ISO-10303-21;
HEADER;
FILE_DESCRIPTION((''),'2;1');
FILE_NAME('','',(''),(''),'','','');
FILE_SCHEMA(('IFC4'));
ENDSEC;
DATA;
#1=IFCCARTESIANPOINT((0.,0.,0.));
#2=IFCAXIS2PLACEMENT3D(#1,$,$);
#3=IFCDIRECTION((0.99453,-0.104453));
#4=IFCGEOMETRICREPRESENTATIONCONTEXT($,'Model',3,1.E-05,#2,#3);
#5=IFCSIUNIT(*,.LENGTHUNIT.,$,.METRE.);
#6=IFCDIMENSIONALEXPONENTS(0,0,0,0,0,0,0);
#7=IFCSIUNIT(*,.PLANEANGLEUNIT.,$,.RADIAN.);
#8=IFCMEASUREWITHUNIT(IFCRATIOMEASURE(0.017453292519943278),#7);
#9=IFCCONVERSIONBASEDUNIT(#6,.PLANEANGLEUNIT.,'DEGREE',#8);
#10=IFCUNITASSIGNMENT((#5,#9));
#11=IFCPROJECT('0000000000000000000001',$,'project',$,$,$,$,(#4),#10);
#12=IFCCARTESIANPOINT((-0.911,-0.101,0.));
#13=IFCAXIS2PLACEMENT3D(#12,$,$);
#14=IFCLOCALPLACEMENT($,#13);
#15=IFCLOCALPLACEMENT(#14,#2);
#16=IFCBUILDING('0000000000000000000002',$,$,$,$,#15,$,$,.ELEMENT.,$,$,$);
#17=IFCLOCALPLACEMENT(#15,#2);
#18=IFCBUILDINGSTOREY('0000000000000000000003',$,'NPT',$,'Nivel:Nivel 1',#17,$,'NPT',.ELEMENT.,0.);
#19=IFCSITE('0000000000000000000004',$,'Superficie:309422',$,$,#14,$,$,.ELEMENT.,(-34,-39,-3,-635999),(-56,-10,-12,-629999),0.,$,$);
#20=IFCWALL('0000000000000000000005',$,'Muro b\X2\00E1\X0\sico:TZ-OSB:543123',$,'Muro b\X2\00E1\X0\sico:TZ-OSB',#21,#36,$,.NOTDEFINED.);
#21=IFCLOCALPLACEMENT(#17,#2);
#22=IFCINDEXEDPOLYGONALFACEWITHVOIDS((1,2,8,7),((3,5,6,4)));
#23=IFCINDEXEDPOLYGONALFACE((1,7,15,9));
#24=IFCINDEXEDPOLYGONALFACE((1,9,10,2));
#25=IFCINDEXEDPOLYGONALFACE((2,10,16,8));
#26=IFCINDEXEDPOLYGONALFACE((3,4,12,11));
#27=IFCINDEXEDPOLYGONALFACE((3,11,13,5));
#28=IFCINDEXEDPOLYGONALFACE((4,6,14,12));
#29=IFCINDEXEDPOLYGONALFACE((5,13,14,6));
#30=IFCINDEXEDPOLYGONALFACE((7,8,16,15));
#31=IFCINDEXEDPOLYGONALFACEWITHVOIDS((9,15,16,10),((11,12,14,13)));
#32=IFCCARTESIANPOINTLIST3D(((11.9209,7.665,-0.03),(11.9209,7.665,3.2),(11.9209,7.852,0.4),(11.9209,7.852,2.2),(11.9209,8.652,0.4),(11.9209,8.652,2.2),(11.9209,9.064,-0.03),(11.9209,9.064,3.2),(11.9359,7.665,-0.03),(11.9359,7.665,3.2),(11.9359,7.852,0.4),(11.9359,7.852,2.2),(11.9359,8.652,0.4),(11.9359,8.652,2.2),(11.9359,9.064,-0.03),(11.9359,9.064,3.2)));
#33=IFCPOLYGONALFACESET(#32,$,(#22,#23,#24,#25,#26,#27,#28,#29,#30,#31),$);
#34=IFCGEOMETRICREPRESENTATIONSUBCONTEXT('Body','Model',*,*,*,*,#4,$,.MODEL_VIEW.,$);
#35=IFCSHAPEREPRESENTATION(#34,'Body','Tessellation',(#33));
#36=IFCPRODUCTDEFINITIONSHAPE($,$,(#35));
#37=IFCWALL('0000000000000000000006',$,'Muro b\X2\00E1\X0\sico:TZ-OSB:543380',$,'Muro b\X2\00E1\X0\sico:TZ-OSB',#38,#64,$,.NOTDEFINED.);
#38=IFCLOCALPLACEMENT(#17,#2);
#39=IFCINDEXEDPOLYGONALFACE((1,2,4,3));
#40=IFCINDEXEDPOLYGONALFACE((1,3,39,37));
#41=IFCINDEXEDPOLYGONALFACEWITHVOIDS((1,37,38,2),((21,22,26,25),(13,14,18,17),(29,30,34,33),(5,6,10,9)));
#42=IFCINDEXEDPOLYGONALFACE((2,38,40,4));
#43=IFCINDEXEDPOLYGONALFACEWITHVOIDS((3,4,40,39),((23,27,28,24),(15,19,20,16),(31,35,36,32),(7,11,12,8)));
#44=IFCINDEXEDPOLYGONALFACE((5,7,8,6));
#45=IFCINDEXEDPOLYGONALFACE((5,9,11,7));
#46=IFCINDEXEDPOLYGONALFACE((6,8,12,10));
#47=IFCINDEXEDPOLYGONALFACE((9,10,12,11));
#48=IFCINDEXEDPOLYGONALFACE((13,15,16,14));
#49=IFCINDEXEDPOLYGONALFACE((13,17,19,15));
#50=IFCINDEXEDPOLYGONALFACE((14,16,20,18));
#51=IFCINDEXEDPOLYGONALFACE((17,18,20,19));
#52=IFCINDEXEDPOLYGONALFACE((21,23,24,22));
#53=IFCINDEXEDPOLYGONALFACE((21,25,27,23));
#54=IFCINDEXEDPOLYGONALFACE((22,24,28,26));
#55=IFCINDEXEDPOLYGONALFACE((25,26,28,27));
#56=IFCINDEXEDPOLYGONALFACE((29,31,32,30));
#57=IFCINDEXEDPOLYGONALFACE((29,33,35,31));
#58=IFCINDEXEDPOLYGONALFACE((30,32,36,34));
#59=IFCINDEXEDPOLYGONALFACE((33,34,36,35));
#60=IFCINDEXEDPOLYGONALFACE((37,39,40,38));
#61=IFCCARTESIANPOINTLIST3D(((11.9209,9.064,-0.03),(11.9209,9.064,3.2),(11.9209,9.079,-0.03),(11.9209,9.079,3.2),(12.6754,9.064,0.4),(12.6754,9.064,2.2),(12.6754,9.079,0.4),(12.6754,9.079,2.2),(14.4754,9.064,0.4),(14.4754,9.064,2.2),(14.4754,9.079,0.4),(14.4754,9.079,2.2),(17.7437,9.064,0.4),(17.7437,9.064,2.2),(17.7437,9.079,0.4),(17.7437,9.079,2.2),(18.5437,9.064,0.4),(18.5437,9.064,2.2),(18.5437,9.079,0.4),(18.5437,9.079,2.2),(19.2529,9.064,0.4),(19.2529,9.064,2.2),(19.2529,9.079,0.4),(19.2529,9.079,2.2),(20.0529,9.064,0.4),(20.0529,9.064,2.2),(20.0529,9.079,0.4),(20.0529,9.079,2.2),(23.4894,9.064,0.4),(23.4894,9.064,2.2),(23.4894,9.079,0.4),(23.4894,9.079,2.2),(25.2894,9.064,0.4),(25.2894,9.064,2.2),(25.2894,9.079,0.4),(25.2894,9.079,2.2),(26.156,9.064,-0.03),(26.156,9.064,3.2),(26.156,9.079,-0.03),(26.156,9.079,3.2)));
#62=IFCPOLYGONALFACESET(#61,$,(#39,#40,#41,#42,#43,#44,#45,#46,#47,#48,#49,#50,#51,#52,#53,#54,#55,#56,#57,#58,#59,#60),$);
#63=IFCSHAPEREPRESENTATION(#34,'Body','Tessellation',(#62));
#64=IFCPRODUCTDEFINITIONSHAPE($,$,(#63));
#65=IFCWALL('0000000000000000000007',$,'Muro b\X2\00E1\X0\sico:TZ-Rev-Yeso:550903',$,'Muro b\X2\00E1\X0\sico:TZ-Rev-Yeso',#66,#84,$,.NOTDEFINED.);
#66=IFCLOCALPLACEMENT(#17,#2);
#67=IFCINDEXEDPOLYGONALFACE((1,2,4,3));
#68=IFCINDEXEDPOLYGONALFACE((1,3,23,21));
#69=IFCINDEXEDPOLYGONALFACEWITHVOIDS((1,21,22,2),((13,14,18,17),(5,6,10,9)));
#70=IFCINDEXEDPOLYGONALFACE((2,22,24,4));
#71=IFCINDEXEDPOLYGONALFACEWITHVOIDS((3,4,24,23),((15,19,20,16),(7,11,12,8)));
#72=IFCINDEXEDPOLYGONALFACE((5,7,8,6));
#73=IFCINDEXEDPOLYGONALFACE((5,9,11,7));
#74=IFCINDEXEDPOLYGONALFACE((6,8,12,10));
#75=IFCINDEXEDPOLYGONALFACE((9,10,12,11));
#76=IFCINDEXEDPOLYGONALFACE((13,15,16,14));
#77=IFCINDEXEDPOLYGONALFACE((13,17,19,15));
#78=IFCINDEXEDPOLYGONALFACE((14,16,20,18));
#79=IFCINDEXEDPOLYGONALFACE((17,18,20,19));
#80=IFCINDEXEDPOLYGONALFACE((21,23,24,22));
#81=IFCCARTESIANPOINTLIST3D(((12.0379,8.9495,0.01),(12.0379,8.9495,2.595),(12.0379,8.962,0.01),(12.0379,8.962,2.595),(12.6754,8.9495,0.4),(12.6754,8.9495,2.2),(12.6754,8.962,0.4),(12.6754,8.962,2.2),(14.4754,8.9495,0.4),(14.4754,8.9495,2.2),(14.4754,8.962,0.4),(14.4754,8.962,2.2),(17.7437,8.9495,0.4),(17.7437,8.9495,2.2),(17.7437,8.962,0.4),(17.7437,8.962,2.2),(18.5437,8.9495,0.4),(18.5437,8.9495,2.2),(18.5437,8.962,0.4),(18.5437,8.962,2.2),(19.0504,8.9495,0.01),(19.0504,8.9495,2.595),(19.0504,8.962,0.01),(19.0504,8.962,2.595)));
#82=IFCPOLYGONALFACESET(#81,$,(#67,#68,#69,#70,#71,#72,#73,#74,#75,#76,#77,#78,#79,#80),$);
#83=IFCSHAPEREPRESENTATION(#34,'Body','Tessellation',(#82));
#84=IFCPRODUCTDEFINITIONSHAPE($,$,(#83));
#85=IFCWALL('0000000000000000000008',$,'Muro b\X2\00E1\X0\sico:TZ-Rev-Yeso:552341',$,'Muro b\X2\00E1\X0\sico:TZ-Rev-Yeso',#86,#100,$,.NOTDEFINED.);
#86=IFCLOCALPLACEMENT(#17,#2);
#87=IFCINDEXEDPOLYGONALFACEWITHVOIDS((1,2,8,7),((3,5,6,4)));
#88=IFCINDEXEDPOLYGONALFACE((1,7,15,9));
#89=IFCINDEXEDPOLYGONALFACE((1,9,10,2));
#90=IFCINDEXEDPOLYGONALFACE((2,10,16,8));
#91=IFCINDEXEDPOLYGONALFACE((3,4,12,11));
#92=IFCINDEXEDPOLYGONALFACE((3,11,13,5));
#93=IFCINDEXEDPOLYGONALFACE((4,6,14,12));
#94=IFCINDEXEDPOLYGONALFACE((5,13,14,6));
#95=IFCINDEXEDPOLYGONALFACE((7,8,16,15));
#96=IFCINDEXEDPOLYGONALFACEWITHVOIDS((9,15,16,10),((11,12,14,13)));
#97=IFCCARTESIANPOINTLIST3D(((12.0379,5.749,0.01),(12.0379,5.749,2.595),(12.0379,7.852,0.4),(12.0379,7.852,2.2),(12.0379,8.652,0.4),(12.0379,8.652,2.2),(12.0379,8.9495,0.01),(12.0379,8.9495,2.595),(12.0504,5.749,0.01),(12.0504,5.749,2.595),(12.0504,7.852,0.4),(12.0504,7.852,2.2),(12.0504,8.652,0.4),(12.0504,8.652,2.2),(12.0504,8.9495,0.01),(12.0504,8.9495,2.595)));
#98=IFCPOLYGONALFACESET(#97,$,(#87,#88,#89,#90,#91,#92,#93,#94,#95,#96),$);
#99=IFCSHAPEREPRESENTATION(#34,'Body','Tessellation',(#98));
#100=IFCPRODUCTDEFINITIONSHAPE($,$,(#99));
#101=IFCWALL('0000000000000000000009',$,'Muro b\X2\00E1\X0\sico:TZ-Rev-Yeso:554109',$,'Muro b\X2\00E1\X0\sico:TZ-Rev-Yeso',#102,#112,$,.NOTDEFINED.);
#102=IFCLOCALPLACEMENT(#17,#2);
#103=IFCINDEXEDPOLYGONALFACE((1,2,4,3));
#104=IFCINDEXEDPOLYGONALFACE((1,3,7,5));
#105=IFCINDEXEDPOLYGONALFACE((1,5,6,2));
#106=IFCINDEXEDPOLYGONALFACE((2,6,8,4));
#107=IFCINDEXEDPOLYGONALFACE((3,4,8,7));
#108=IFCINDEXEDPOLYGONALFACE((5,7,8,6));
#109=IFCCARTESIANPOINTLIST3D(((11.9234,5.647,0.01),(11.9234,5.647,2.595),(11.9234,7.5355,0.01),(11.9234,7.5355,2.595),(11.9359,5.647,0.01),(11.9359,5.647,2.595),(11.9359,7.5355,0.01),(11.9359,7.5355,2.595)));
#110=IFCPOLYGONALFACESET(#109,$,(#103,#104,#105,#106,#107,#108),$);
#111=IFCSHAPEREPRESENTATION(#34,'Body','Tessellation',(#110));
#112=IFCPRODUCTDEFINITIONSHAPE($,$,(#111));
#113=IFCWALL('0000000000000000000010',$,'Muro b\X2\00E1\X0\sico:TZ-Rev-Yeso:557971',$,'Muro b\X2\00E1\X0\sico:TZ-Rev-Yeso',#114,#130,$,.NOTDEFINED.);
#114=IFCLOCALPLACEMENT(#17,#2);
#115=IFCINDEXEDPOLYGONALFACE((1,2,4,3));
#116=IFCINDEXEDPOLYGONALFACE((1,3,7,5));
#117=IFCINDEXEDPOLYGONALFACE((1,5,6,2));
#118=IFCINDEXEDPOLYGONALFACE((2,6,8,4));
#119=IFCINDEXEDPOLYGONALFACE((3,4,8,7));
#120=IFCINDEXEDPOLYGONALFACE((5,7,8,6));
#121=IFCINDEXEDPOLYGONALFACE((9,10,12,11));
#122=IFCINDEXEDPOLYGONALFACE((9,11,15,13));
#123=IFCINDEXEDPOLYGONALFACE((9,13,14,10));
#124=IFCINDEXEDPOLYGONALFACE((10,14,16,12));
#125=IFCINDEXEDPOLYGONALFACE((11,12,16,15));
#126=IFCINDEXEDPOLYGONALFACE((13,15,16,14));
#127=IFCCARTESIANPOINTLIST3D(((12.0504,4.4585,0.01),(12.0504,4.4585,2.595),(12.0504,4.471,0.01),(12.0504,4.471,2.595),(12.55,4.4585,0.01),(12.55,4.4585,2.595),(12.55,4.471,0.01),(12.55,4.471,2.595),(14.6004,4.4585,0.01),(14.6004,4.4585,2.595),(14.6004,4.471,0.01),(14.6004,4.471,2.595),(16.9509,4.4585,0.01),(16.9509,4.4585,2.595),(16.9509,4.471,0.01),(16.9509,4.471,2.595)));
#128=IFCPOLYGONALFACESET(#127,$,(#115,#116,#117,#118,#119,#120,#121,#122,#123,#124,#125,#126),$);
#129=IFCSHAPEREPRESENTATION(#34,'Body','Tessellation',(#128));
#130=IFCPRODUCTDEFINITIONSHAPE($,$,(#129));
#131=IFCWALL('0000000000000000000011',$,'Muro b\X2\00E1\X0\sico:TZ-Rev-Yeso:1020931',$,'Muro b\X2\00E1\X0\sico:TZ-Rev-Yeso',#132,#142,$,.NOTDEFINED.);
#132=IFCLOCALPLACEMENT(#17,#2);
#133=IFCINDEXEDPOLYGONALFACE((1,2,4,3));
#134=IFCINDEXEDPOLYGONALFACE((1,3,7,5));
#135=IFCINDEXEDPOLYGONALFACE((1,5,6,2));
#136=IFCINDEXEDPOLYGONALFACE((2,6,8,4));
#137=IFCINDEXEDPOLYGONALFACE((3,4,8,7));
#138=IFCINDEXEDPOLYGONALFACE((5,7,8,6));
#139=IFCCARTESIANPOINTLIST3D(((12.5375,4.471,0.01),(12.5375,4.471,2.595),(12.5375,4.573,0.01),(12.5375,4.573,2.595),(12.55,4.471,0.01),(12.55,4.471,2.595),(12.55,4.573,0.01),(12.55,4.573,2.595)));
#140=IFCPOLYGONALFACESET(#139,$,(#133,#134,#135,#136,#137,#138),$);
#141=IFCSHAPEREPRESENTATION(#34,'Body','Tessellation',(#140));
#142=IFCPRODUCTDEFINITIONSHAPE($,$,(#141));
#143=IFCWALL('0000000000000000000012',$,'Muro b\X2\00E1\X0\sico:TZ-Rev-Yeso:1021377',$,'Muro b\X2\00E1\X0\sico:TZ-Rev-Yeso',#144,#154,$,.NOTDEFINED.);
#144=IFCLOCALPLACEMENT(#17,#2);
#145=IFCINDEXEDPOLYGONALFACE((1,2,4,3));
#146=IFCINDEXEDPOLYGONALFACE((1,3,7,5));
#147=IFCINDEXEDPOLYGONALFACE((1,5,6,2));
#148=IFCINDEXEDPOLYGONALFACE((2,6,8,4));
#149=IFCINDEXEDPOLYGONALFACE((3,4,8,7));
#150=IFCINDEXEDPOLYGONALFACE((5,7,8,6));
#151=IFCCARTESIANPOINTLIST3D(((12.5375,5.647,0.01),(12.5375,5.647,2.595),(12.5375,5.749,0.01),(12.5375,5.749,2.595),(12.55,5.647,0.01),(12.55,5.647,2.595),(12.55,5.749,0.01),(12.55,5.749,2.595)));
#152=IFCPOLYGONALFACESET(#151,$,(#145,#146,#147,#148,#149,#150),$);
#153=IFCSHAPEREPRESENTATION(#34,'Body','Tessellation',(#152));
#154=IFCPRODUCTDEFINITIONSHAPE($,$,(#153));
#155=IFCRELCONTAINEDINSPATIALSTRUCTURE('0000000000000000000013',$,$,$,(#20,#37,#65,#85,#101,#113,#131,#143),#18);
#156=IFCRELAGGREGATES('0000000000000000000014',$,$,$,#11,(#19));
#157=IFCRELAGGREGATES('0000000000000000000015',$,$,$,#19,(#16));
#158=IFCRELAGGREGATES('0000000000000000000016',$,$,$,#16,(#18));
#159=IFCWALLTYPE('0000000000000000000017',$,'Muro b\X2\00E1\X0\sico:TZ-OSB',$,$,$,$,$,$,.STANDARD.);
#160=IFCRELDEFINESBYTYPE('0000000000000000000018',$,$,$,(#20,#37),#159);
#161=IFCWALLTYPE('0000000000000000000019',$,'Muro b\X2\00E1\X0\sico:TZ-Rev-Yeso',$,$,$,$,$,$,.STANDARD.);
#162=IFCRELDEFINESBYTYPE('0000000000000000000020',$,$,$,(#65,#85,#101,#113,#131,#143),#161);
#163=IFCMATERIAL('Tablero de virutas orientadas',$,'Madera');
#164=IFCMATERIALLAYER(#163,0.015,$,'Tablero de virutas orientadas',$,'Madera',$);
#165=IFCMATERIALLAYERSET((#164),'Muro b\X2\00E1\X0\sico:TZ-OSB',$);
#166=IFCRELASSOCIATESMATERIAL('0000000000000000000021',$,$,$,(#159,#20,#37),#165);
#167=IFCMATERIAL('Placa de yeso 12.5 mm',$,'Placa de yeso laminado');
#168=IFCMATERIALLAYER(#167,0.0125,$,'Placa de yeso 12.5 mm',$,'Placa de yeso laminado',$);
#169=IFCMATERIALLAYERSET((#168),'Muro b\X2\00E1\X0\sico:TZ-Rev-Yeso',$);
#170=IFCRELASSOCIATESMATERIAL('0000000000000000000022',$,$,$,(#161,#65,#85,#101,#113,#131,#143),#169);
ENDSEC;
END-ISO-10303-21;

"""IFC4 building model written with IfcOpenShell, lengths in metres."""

from ifc_helpers import new_model, entity, si_unit, converted_unit, direction, frame, frame_2d, origin, origin_2d_with_axis, place, context, subcontext, project, spatial, rectangle, extrude, material, layer, layer_set, layer_usage, type_object, element, save


model = new_model("IFC4")

# Units and contexts
model_context = context("Model", 3, precision=1e-05, world=origin(), true_north=direction((0.99453, -0.104453)))
body_context = subcontext(model_context, "Body", "Model", "MODEL_VIEW")
ifc_project = project(units=[si_unit("LENGTHUNIT", "METRE"), converted_unit("PLANEANGLEUNIT", "DEGREE", entity("IfcRatioMeasure", 0.017453292519943278), si_unit("PLANEANGLEUNIT", "RADIAN"), dimensions=[0, 0, 0, 0, 0, 0, 0])], contexts=[model_context])

# Site, building, storey
site_placement = place(None, frame((-0.911, -0.101, 0.0)))
site = spatial("IfcSite", under=ifc_project, at=site_placement, Name="Superficie:309422", CompositionType="ELEMENT", RefLatitude=(-34, -39, -3, -635999), RefLongitude=(-56, -10, -12, -629999), RefElevation=0.0)
building_placement = place(site_placement, origin())
building = spatial("IfcBuilding", under=site, at=building_placement, CompositionType="ELEMENT")
storey_placement = place(building_placement, origin())
storey = spatial("IfcBuildingStorey", under=building, at=storey_placement, Name="NPT", ObjectType="Nivel:Nivel 1", LongName="NPT", CompositionType="ELEMENT", Elevation=0.0)

# Wall, opening
ifc_material_1 = material(Name="Tablero de virutas orientadas", Category="Madera")
ifc_layer_1 = layer(ifc_material_1, 0.015, Name="Tablero de virutas orientadas", Category="Madera")
ifc_layer_set_1 = layer_set([ifc_layer_1], Name="Muro básico:TZ-OSB")
ifc_layer_usage_1 = layer_usage(ifc_layer_set_1, "AXIS2", "NEGATIVE", 0.0075)
wall_type_1 = type_object("IfcWallType", Name="Muro básico:TZ-OSB", PredefinedType="STANDARD", material=ifc_layer_set_1)
wall_1_placement = place(storey_placement, frame((11.9284, 7.665, -0.03), z_axis=(0.0, 0.0, 1.0), x_axis=(0.0, 1.0, 0.0)))
wall_1 = element("IfcWall", 1, at=wall_1_placement, inside=storey, type_object=wall_type_1, material=ifc_layer_usage_1, Name="Muro básico:TZ-OSB:543123", ObjectType="Muro básico:TZ-OSB", PredefinedType="NOTDEFINED", context=body_context, shape_type="SweptSolid", body=[
    extrude(rectangle(XDim=1.399, YDim=0.015, at=frame_2d((0.6995, 0.0), x_axis=(-1.0, 0.0))), origin(), (0.0, 0.0, 1.0), 3.23),
])
opening_1_placement = place(wall_1_placement, frame((0.187, 1.4145, 0.43)))
element("IfcOpeningElement", 2, at=opening_1_placement, cuts=wall_1, PredefinedType="OPENING", context=body_context, shape_type="SweptSolid", body=[
    extrude(rectangle(XDim=1.8, YDim=0.8, at=frame_2d((0.0, 0.0), x_axis=(1.0, 0.0))), frame((0.4, -3.048, 0.9), z_axis=(0.0, 1.0, 0.0), x_axis=(0.0, 0.0, 1.0)), (0.0, 0.0, 1.0), 3.048),
])

# Walls, openings
ifc_layer_usage_2 = layer_usage(ifc_layer_set_1, "AXIS2", "NEGATIVE", 0.0075)
wall_2_placement = place(storey_placement, frame((11.9209, 9.0715, -0.03)))
wall_2 = element("IfcWall", 3, at=wall_2_placement, inside=storey, type_object=wall_type_1, material=ifc_layer_usage_2, Name="Muro básico:TZ-OSB:543380", ObjectType="Muro básico:TZ-OSB", PredefinedType="NOTDEFINED", context=body_context, shape_type="SweptSolid", body=[
    extrude(rectangle(XDim=14.235, YDim=0.015, at=frame_2d((7.1175, 0.0), x_axis=(-1.0, 0.0))), origin(), (0.0, 0.0, 1.0), 3.23),
])
opening_2_placement = place(wall_2_placement, frame((5.8228, -1.6335, 0.43)))
element("IfcOpeningElement", 4, at=opening_2_placement, cuts=wall_2, PredefinedType="OPENING", context=body_context, shape_type="SweptSolid", body=[
    extrude(rectangle(XDim=1.8, YDim=0.8, at=frame_2d((0.0, 0.0), x_axis=(1.0, 0.0))), frame((0.4, 0.0, 0.9), z_axis=(0.0, 1.0, 0.0), x_axis=(0.0, 0.0, 1.0)), (0.0, 0.0, 1.0), 3.048),
])
opening_3_placement = place(wall_2_placement, frame((0.7545, -1.6335, 0.43)))
element("IfcOpeningElement", 5, at=opening_3_placement, cuts=wall_2, PredefinedType="OPENING", context=body_context, shape_type="SweptSolid", body=[
    extrude(rectangle(XDim=1.8, YDim=1.8, at=origin_2d_with_axis()), frame((0.9, 0.0, 0.9), z_axis=(0.0, 1.0, 0.0), x_axis=(0.0, 0.0, 1.0)), (0.0, 0.0, 1.0), 3.048),
])
opening_4_placement = place(wall_2_placement, frame((11.5685, -1.6335, 0.43)))
element("IfcOpeningElement", 6, at=opening_4_placement, cuts=wall_2, PredefinedType="OPENING", context=body_context, shape_type="SweptSolid", body=[
    extrude(rectangle(XDim=1.8, YDim=1.8, at=frame_2d((0.0, 0.0), x_axis=(0.0, 1.0))), frame((0.9, 0.0, 0.9), z_axis=(0.0, 1.0, 0.0), x_axis=(-1.0, 0.0, 0.0)), (0.0, 0.0, 1.0), 3.048),
])
opening_5_placement = place(wall_2_placement, frame((7.332, -1.6335, 0.43)))
element("IfcOpeningElement", 7, at=opening_5_placement, cuts=wall_2, PredefinedType="OPENING", context=body_context, shape_type="SweptSolid", body=[
    extrude(rectangle(XDim=1.8, YDim=0.8, at=frame_2d((0.0, 0.0), x_axis=(1.0, 0.0))), frame((0.4, 0.0, 0.9), z_axis=(0.0, 1.0, 0.0), x_axis=(0.0, 0.0, 1.0)), (0.0, 0.0, 1.0), 3.048),
])
ifc_material_2 = material(Name="Placa de yeso 12.5 mm", Category="Placa de yeso laminado")
ifc_layer_2 = layer(ifc_material_2, 0.0125, Name="Placa de yeso 12.5 mm", Category="Placa de yeso laminado")
ifc_layer_set_2 = layer_set([ifc_layer_2], Name="Muro básico:TZ-Rev-Yeso")
ifc_layer_usage_3 = layer_usage(ifc_layer_set_2, "AXIS2", "NEGATIVE", 0.0063)
wall_type_2 = type_object("IfcWallType", Name="Muro básico:TZ-Rev-Yeso", PredefinedType="STANDARD", material=ifc_layer_set_2)
wall_3_placement = place(storey_placement, frame((12.0379, 8.9558, 0.01)))
wall_3 = element("IfcWall", 8, at=wall_3_placement, inside=storey, type_object=wall_type_2, material=ifc_layer_usage_3, Name="Muro básico:TZ-Rev-Yeso:550903", ObjectType="Muro básico:TZ-Rev-Yeso", PredefinedType="NOTDEFINED", context=body_context, shape_type="SweptSolid", body=[
    extrude(rectangle(XDim=7.0125, YDim=0.0125, at=frame_2d((3.5062, 0.0), x_axis=(-1.0, 0.0))), origin(), (0.0, 0.0, 1.0), 2.585),
])
opening_6_placement = place(wall_3_placement, frame((0.6375, -1.5178, 0.39)))
element("IfcOpeningElement", 9, at=opening_6_placement, cuts=wall_3, PredefinedType="OPENING", context=body_context, shape_type="SweptSolid", body=[
    extrude(rectangle(XDim=1.8, YDim=1.8, at=origin_2d_with_axis()), frame((0.9, 0.0, 0.9), z_axis=(0.0, 1.0, 0.0), x_axis=(0.0, 0.0, 1.0)), (0.0, 0.0, 1.0), 3.048),
])
opening_7_placement = place(wall_3_placement, frame((5.7058, -1.5178, 0.39)))
element("IfcOpeningElement", 10, at=opening_7_placement, cuts=wall_3, PredefinedType="OPENING", context=body_context, shape_type="SweptSolid", body=[
    extrude(rectangle(XDim=1.8, YDim=0.8, at=frame_2d((0.0, 0.0), x_axis=(1.0, 0.0))), frame((0.4, 0.0, 0.9), z_axis=(0.0, 1.0, 0.0), x_axis=(0.0, 0.0, 1.0)), (0.0, 0.0, 1.0), 3.048),
])

# Wall, opening
ifc_layer_usage_4 = layer_usage(ifc_layer_set_2, "AXIS2", "NEGATIVE", 0.0063)
wall_4_placement = place(storey_placement, frame((12.0442, 5.749, 0.01), z_axis=(0.0, 0.0, 1.0), x_axis=(0.0, 1.0, 0.0)))
wall_4 = element("IfcWall", 11, at=wall_4_placement, inside=storey, type_object=wall_type_2, material=ifc_layer_usage_4, Name="Muro básico:TZ-Rev-Yeso:552341", ObjectType="Muro básico:TZ-Rev-Yeso", PredefinedType="NOTDEFINED", context=body_context, shape_type="SweptSolid", body=[
    extrude(rectangle(XDim=3.2005, YDim=0.0125, at=frame_2d((1.6003, 0.0), x_axis=(-1.0, 0.0))), origin(), (0.0, 0.0, 1.0), 2.585),
])
opening_8_placement = place(wall_4_placement, frame((2.103, 1.5303, 0.39)))
element("IfcOpeningElement", 12, at=opening_8_placement, cuts=wall_4, PredefinedType="OPENING", context=body_context, shape_type="SweptSolid", body=[
    extrude(rectangle(XDim=1.8, YDim=0.8, at=frame_2d((0.0, 0.0), x_axis=(1.0, 0.0))), frame((0.4, -3.048, 0.9), z_axis=(0.0, 1.0, 0.0), x_axis=(0.0, 0.0, 1.0)), (0.0, 0.0, 1.0), 3.048),
])

# Wall
ifc_layer_usage_5 = layer_usage(ifc_layer_set_2, "AXIS2", "NEGATIVE", 0.0063)
wall_5_placement = place(storey_placement, frame((11.9297, 7.5355, 0.01), z_axis=(0.0, 0.0, 1.0), x_axis=(0.0, -1.0, 0.0)))
element("IfcWall", 13, at=wall_5_placement, inside=storey, type_object=wall_type_2, material=ifc_layer_usage_5, Name="Muro básico:TZ-Rev-Yeso:554109", ObjectType="Muro básico:TZ-Rev-Yeso", PredefinedType="NOTDEFINED", context=body_context, shape_type="SweptSolid", body=[
    extrude(rectangle(XDim=1.8885, YDim=0.0125, at=frame_2d((0.9442, 0.0), x_axis=(-1.0, 0.0))), origin(), (0.0, 0.0, 1.0), 2.585),
])

# Wall, opening
ifc_layer_usage_6 = layer_usage(ifc_layer_set_2, "AXIS2", "NEGATIVE", 0.0063)
wall_6_placement = place(storey_placement, frame((12.0504, 4.4648, 0.01)))
wall_6 = element("IfcWall", 14, at=wall_6_placement, inside=storey, type_object=wall_type_2, material=ifc_layer_usage_6, Name="Muro básico:TZ-Rev-Yeso:557971", ObjectType="Muro básico:TZ-Rev-Yeso", PredefinedType="NOTDEFINED", context=body_context, shape_type="SweptSolid", body=[
    extrude(rectangle(XDim=0.0125, YDim=4.9005, at=frame_2d((2.4503, 0.0), x_axis=(0.0, -1.0))), origin(), (0.0, 0.0, 1.0), 2.585),
])
opening_9_placement = place(wall_6_placement, frame((2.55, 0.0062, -0.01)))
element("IfcOpeningElement", 15, at=opening_9_placement, cuts=wall_6, PredefinedType="OPENING", context=body_context, shape_type="SweptSolid", body=[
    extrude(rectangle(XDim=2.6, YDim=2.0504, at=frame_2d((1.3, 1.0252), x_axis=(1.0, 0.0))), frame((0.0, 0.0, 0.0), z_axis=(0.0, -1.0, 0.0), x_axis=(0.0, 0.0, 1.0)), (0.0, 0.0, 1.0), 0.0125),
])

# Walls
ifc_layer_usage_7 = layer_usage(ifc_layer_set_2, "AXIS2", "POSITIVE", -0.0063)
wall_7_placement = place(storey_placement, frame((12.5437, 4.573, 0.01), z_axis=(0.0, 0.0, 1.0), x_axis=(0.0, -1.0, 0.0)))
element("IfcWall", 16, at=wall_7_placement, inside=storey, type_object=wall_type_2, material=ifc_layer_usage_7, Name="Muro básico:TZ-Rev-Yeso:1020931", ObjectType="Muro básico:TZ-Rev-Yeso", PredefinedType="NOTDEFINED", context=body_context, shape_type="SweptSolid", body=[
    extrude(rectangle(XDim=0.102, YDim=0.0125, at=frame_2d((0.051, 0.0), x_axis=(-1.0, 0.0))), origin(), (0.0, 0.0, 1.0), 2.585),
])
ifc_layer_usage_8 = layer_usage(ifc_layer_set_2, "AXIS2", "POSITIVE", -0.0063)
wall_8_placement = place(storey_placement, frame((12.5437, 5.647, 0.01), z_axis=(0.0, 0.0, 1.0), x_axis=(0.0, 1.0, 0.0)))
element("IfcWall", 17, at=wall_8_placement, inside=storey, type_object=wall_type_2, material=ifc_layer_usage_8, Name="Muro básico:TZ-Rev-Yeso:1021377", ObjectType="Muro básico:TZ-Rev-Yeso", PredefinedType="NOTDEFINED", context=body_context, shape_type="SweptSolid", body=[
    extrude(rectangle(XDim=0.102, YDim=0.0125, at=frame_2d((0.051, 0.0), x_axis=(-1.0, 0.0))), origin(), (0.0, 0.0, 1.0), 2.585),
])

save(model, "model.ifc")
